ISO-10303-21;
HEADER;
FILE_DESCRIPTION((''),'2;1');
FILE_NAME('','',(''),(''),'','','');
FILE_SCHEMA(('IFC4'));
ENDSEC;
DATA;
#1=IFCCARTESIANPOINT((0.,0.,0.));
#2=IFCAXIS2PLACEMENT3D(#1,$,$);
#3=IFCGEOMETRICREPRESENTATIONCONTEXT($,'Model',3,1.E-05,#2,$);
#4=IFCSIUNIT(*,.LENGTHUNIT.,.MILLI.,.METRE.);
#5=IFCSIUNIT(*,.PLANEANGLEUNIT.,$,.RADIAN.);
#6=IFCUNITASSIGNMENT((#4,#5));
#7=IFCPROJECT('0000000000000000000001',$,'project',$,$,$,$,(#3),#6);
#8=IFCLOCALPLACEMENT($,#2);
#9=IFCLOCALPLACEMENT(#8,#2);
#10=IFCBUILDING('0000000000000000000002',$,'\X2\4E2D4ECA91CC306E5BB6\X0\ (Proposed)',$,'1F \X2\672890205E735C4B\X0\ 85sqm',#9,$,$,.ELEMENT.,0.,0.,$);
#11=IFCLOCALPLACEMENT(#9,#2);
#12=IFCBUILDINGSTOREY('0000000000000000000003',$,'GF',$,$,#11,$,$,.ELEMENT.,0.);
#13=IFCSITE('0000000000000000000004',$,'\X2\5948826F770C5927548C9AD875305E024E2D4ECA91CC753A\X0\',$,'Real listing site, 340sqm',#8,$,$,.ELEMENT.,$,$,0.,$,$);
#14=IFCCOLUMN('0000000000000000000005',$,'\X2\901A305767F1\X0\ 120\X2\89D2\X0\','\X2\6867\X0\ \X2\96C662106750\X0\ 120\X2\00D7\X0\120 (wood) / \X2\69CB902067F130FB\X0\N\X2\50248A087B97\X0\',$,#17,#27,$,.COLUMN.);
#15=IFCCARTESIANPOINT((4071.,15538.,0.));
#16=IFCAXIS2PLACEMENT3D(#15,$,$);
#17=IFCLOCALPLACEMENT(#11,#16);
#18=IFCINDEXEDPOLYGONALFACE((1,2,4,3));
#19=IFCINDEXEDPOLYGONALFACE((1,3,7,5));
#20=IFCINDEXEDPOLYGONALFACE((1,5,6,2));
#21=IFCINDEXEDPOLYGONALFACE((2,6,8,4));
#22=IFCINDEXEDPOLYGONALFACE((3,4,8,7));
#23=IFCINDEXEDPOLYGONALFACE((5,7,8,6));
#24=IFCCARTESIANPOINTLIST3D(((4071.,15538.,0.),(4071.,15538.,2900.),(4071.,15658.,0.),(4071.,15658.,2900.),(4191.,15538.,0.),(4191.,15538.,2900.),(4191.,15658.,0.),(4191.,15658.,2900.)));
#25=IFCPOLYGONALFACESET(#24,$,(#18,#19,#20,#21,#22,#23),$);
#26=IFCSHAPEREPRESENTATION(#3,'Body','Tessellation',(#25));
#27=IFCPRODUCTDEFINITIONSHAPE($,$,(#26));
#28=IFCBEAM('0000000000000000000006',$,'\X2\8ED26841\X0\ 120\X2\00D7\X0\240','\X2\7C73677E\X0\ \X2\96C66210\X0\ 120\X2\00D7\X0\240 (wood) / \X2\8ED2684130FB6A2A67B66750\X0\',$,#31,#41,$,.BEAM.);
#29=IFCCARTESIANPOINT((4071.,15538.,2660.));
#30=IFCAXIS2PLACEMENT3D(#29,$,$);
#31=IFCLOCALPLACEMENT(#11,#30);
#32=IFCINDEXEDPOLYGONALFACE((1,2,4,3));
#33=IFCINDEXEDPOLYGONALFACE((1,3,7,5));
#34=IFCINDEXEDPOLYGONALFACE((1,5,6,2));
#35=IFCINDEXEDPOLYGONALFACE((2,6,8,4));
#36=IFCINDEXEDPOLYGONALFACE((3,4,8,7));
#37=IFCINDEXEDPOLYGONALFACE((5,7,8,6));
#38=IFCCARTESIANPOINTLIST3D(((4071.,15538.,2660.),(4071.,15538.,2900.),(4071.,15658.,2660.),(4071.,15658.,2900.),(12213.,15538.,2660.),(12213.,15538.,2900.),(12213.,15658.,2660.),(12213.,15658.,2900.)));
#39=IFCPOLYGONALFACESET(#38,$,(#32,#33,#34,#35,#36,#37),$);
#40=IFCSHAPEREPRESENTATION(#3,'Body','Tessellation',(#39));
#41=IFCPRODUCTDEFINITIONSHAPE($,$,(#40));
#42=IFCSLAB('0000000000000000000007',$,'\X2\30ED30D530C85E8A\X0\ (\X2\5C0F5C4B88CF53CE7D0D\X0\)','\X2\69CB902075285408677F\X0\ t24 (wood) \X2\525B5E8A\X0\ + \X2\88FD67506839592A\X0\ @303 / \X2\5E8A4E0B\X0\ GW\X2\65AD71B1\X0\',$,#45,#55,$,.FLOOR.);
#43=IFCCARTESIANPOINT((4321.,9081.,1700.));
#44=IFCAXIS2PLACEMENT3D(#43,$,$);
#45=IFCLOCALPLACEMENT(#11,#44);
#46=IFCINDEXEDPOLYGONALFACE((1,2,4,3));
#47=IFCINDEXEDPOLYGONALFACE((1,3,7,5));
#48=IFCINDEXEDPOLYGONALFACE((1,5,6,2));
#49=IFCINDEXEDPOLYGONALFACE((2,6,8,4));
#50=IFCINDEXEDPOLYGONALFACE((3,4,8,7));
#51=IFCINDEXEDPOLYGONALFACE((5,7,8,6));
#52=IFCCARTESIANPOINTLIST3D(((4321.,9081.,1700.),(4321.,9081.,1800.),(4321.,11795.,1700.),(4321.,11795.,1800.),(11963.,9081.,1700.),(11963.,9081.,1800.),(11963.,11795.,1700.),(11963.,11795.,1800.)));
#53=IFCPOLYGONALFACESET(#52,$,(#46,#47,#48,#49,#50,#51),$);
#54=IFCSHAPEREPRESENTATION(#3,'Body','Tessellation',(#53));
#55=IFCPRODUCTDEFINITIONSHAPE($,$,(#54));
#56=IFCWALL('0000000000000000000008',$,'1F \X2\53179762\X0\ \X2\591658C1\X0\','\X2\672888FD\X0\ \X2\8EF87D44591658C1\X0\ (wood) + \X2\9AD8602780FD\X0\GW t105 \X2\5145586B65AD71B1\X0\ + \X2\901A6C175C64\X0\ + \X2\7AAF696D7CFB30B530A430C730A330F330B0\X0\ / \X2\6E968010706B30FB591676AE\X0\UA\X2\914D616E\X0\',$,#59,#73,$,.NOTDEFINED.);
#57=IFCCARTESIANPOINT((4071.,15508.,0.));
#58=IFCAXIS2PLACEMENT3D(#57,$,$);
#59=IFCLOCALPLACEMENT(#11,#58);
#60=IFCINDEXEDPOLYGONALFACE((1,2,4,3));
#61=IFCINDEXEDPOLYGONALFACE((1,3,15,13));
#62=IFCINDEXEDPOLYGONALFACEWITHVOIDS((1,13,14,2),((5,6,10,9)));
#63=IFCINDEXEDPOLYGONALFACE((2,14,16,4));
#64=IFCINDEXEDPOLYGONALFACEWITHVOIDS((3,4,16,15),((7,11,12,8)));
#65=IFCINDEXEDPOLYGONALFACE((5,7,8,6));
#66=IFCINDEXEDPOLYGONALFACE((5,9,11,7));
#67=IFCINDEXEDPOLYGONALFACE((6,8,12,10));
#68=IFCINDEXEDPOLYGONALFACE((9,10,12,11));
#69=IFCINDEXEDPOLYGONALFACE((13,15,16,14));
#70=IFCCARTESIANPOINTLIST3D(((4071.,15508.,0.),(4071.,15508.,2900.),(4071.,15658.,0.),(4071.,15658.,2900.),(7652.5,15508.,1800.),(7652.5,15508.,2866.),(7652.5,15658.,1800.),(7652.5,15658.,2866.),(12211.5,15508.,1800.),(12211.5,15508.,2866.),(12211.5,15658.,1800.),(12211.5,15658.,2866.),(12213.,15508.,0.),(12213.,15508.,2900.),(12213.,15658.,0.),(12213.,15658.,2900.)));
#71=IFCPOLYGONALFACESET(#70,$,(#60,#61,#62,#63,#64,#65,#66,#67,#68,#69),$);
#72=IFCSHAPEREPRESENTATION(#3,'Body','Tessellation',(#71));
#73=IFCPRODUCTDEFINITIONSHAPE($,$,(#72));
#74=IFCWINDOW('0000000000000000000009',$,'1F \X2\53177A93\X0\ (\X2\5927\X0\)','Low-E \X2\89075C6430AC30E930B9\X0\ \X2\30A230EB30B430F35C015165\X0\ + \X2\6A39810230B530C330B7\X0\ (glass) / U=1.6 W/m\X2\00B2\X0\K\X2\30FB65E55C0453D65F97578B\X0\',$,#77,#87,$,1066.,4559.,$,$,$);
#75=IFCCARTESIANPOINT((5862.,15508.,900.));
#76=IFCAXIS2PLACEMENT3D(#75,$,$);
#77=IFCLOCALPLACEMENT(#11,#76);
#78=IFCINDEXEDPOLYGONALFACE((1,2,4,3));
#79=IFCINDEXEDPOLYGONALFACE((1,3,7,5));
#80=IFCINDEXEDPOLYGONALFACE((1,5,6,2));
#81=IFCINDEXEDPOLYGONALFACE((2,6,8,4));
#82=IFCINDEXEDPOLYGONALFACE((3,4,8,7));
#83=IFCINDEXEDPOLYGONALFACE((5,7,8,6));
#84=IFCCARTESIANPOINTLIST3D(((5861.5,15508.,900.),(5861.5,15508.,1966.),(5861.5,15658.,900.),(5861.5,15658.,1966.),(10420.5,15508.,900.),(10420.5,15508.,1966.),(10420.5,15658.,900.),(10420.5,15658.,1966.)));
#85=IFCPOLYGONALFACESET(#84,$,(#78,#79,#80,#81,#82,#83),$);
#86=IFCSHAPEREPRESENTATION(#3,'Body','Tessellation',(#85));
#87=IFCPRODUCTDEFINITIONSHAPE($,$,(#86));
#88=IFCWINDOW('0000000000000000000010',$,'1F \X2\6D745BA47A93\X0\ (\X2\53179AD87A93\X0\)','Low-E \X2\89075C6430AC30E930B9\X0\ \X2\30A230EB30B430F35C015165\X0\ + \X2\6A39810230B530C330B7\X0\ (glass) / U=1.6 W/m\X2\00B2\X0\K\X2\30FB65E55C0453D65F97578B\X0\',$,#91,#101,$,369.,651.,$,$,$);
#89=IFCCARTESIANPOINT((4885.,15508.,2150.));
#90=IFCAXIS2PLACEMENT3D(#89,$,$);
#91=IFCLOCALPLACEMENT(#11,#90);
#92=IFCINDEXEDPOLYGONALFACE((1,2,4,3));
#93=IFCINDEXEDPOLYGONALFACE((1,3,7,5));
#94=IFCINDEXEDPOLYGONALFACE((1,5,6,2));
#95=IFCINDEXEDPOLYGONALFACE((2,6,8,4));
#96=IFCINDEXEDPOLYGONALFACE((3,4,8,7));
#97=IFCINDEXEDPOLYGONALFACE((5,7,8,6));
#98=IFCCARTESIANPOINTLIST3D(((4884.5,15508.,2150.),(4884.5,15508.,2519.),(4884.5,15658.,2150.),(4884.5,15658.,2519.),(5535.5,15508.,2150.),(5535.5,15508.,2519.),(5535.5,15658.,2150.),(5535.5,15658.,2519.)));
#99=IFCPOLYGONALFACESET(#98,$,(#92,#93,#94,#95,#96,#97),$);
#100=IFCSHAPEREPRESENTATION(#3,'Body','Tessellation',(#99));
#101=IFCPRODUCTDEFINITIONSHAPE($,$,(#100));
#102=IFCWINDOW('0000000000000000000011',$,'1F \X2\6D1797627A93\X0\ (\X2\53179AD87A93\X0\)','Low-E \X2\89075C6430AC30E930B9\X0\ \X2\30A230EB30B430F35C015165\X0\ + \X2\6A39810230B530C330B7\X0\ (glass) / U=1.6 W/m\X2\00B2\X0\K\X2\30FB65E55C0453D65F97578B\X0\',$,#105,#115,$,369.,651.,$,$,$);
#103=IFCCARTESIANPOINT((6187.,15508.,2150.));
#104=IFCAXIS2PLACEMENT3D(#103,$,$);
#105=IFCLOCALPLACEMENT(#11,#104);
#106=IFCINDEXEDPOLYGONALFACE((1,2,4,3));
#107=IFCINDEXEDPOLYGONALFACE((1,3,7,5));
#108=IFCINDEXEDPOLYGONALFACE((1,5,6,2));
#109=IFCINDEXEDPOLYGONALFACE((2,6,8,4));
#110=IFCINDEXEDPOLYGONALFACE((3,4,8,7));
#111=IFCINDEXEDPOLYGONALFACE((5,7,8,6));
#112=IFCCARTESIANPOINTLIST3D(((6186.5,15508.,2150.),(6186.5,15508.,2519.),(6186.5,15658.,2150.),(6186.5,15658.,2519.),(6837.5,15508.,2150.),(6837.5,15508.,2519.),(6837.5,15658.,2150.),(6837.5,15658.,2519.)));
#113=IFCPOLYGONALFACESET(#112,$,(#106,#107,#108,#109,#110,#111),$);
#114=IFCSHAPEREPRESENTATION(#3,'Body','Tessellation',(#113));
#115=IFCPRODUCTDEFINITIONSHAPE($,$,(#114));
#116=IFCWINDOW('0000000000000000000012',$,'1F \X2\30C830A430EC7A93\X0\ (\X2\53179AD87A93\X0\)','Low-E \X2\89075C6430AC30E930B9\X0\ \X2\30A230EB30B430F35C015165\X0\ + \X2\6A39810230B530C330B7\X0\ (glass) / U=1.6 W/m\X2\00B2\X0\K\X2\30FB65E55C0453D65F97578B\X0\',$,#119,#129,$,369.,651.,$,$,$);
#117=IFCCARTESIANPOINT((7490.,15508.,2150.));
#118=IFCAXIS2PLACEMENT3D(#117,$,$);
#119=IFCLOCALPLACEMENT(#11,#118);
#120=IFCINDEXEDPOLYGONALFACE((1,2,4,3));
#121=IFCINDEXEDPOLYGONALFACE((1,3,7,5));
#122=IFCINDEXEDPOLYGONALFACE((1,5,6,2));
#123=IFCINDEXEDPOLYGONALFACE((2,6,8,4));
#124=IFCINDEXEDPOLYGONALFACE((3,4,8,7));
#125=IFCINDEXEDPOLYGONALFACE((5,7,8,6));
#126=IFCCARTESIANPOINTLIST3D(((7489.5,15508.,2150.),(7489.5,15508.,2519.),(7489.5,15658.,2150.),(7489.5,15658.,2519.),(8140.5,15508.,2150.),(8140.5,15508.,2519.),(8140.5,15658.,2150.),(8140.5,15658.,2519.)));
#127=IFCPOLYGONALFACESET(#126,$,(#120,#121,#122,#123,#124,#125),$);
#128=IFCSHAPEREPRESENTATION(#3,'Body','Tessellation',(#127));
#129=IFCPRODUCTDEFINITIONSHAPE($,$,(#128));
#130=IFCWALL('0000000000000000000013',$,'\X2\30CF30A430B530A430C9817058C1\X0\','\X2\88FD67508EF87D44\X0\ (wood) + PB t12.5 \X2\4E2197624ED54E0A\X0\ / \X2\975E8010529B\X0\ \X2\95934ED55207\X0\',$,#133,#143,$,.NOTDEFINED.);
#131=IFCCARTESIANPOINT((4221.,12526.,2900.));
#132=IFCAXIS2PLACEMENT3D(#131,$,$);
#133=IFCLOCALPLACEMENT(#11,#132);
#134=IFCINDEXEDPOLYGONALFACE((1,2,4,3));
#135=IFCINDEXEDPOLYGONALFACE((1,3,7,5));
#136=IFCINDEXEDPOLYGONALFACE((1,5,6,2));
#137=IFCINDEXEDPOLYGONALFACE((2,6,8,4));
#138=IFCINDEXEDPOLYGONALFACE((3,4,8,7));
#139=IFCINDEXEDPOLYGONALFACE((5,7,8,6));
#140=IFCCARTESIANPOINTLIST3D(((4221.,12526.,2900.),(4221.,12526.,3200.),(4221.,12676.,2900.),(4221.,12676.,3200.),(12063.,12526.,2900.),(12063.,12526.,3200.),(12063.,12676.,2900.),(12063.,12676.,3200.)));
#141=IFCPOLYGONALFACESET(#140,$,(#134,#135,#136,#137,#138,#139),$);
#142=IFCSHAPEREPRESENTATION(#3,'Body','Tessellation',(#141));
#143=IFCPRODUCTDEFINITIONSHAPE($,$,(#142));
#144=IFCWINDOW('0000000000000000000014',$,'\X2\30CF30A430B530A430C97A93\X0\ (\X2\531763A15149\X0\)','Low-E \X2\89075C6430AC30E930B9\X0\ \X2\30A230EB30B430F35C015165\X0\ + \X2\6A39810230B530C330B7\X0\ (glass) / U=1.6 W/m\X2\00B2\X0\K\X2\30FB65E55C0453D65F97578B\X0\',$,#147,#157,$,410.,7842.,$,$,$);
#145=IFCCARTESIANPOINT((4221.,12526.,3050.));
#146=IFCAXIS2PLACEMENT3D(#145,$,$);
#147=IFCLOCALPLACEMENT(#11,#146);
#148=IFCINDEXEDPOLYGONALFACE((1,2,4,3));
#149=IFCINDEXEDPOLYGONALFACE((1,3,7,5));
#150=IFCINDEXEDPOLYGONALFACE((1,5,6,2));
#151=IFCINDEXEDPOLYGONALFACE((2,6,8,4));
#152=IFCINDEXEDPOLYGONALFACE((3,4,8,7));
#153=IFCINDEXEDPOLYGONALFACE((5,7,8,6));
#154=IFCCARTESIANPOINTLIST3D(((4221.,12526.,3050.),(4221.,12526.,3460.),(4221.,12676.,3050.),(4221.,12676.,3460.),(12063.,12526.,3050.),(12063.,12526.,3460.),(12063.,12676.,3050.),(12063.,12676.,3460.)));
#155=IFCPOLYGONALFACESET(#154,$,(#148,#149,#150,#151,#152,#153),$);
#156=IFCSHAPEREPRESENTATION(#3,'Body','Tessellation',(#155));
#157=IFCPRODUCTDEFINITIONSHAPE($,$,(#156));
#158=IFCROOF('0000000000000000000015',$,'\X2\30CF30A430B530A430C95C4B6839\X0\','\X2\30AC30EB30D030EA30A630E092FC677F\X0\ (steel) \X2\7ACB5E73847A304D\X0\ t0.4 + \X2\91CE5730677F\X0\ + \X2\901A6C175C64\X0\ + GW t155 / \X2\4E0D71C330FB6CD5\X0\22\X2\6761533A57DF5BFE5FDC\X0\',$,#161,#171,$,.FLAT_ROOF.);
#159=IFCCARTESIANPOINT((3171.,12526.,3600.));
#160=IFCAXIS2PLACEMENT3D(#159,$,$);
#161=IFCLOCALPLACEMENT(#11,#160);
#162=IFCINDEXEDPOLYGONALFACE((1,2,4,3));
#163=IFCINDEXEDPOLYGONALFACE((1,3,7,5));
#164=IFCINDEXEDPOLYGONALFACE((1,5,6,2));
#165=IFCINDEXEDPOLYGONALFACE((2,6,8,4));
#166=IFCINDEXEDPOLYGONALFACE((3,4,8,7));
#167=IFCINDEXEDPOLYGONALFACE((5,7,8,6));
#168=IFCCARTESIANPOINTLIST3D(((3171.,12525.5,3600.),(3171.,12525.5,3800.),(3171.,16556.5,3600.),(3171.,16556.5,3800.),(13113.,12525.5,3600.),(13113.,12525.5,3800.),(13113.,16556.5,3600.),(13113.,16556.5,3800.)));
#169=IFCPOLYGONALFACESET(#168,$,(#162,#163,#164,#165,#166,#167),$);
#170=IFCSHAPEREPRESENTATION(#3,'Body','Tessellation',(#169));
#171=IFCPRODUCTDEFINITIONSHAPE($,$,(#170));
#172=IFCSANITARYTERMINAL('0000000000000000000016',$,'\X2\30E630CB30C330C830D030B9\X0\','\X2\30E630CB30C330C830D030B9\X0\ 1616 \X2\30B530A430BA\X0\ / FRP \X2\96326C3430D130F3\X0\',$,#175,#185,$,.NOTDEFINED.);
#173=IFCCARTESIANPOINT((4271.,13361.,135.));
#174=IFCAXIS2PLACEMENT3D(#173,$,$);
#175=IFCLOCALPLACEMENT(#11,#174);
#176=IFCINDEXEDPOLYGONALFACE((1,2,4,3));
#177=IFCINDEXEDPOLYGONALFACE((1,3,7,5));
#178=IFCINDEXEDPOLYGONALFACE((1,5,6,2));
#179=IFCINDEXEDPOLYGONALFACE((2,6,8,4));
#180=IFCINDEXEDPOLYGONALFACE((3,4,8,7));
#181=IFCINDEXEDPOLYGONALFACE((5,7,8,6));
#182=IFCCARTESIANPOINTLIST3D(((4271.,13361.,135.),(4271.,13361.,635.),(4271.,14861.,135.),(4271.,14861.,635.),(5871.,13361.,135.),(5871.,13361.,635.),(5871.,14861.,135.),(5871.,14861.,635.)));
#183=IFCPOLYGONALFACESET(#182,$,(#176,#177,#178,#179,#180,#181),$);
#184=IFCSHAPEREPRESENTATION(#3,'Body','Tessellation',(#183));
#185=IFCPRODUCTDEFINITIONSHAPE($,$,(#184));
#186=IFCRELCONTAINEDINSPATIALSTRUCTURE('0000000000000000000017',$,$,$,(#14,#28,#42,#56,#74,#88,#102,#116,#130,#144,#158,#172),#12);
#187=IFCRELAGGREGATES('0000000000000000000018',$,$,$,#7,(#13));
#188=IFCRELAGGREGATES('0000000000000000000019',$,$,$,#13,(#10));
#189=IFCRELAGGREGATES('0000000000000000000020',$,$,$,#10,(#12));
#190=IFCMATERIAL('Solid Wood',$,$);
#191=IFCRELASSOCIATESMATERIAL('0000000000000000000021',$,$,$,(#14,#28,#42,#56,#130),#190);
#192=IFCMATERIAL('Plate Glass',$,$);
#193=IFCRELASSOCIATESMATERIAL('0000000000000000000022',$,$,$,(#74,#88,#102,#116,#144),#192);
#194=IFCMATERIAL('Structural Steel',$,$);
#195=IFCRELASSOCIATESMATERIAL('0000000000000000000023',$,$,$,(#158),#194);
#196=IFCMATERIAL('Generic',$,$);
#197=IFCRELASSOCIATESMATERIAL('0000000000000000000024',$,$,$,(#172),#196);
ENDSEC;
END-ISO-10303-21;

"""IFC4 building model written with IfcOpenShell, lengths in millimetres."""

from ifc_helpers import new_model, si_unit, frame, frame_2d, origin, place, context, project, spatial, rectangle, extrude, material, element, fill, save


model = new_model("IFC4")

# Units and contexts
model_context = context("Model", 3, precision=1e-05, world=origin())
ifc_project = project(units=[si_unit("LENGTHUNIT", "METRE", prefix="MILLI"), si_unit("PLANEANGLEUNIT", "RADIAN")], contexts=[model_context])

# Site, building, storey
site_placement = place(None, origin())
site = spatial("IfcSite", under=ifc_project, at=site_placement, Name="奈良県大和高田市中今里町", ObjectType="Real listing site, 340sqm", CompositionType="ELEMENT", RefElevation=0.0)
building_placement = place(site_placement, origin())
building = spatial("IfcBuilding", under=site, at=building_placement, Name="中今里の家 (Proposed)", ObjectType="1F 木造平屋 85sqm", CompositionType="ELEMENT", ElevationOfRefHeight=0.0, ElevationOfTerrain=0.0)
storey_placement = place(building_placement, origin())
storey = spatial("IfcBuildingStorey", under=building, at=storey_placement, Name="GF", CompositionType="ELEMENT", Elevation=0.0)

# Column
ifc_material_1 = material(Name="Solid Wood")
column_1_placement = place(storey_placement, frame((4071.0, 15538.0, 0.0)))
element("IfcColumn", 1, at=column_1_placement, inside=storey, material=ifc_material_1, Name="通し柱 120角", Description="桧 集成材 120×120 (wood) / 構造柱・N値計算", PredefinedType="COLUMN", context=model_context, shape_type="SweptSolid", body=[
    extrude(rectangle(XDim=120.0, YDim=120.0, at=frame_2d((60.0, 60.0))), frame((4071.0, 15538.0, 0.0)), (0.0, 0.0, 1.0), 2900.0),
])

# Beam
beam_1_placement = place(storey_placement, frame((4071.0, 15538.0, 2660.0)))
element("IfcBeam", 2, at=beam_1_placement, inside=storey, material=ifc_material_1, Name="軒桁 120×240", Description="米松 集成 120×240 (wood) / 軒桁・横架材", PredefinedType="BEAM", context=model_context, shape_type="SweptSolid", body=[
    extrude(rectangle(XDim=8142.0, YDim=120.0, at=frame_2d((4071.0, 60.0))), frame((4071.0, 15538.0, 2660.0)), (0.0, 0.0, 1.0), 240.0),
])

# Slab
slab_placement = place(storey_placement, frame((4321.0, 9081.0, 1700.0)))
element("IfcSlab", 3, at=slab_placement, inside=storey, material=ifc_material_1, Name="ロフト床 (小屋裏収納)", Description="構造用合板 t24 (wood) 剛床 + 製材根太 @303 / 床下 GW断熱", PredefinedType="FLOOR", context=model_context, shape_type="SweptSolid", body=[
    extrude(rectangle(XDim=7642.0, YDim=2714.0, at=frame_2d((3821.0, 1357.0))), frame((4321.0, 9081.0, 1700.0)), (0.0, 0.0, 1.0), 100.0),
])

# Wall, openings, windows
wall_1_placement = place(storey_placement, frame((4071.0, 15508.0, 0.0)))
wall_1 = element("IfcWall", 4, at=wall_1_placement, inside=storey, material=ifc_material_1, Name="1F 北面 外壁", Description="木製 軸組外壁 (wood) + 高性能GW t105 充填断熱 + 通気層 + 窯業系サイディング / 準耐火・外皮UA配慮", PredefinedType="NOTDEFINED", context=model_context, shape_type="SweptSolid", body=[
    extrude(rectangle(XDim=8142.0, YDim=150.0, at=frame_2d((4071.0, 75.0))), frame((4071.0, 15508.0, 0.0)), (0.0, 0.0, 1.0), 2900.0),
])
opening_1_placement = place(storey_placement, frame((5862.0, 15508.0, 900.0)))
opening_1 = element("IfcOpeningElement", 5, at=opening_1_placement, cuts=wall_1, PredefinedType="NOTDEFINED", context=model_context, shape_type="SweptSolid", body=[
    extrude(rectangle(XDim=4559.0, YDim=150.0, at=frame_2d((2279.0, 75.0))), frame((5862.0, 15508.0, 900.0)), (0.0, 0.0, 1.0), 1066.0),
])
opening_2_placement = place(storey_placement, frame((4885.0, 15508.0, 2150.0)))
opening_2 = element("IfcOpeningElement", 6, at=opening_2_placement, cuts=wall_1, PredefinedType="NOTDEFINED", context=model_context, shape_type="SweptSolid", body=[
    extrude(rectangle(XDim=651.0, YDim=150.0, at=frame_2d((325.0, 75.0))), frame((4885.0, 15508.0, 2150.0)), (0.0, 0.0, 1.0), 369.0),
])
opening_3_placement = place(storey_placement, frame((6187.0, 15508.0, 2150.0)))
opening_3 = element("IfcOpeningElement", 7, at=opening_3_placement, cuts=wall_1, PredefinedType="NOTDEFINED", context=model_context, shape_type="SweptSolid", body=[
    extrude(rectangle(XDim=651.0, YDim=150.0, at=frame_2d((325.0, 75.0))), frame((6187.0, 15508.0, 2150.0)), (0.0, 0.0, 1.0), 369.0),
])
opening_4_placement = place(storey_placement, frame((7490.0, 15508.0, 2150.0)))
opening_4 = element("IfcOpeningElement", 8, at=opening_4_placement, cuts=wall_1, PredefinedType="NOTDEFINED", context=model_context, shape_type="SweptSolid", body=[
    extrude(rectangle(XDim=651.0, YDim=150.0, at=frame_2d((325.0, 75.0))), frame((7490.0, 15508.0, 2150.0)), (0.0, 0.0, 1.0), 369.0),
])
ifc_material_2 = material(Name="Plate Glass")
window_1_placement = place(storey_placement, frame((5862.0, 15508.0, 900.0)))
window_1 = element("IfcWindow", 9, at=window_1_placement, inside=storey, material=ifc_material_2, Name="1F 北窓 (大)", Description="Low-E 複層ガラス アルゴン封入 + 樹脂サッシ (glass) / U=1.6 W/m²K・日射取得型", OverallHeight=1066.0, OverallWidth=4559.0, context=model_context, shape_type="SweptSolid", body=[
    extrude(rectangle(XDim=4559.0, YDim=150.0, at=frame_2d((2279.0, 75.0))), frame((5862.0, 15508.0, 900.0)), (0.0, 0.0, 1.0), 1066.0),
])
fill(opening_1, window_1)
window_2_placement = place(storey_placement, frame((4885.0, 15508.0, 2150.0)))
window_2 = element("IfcWindow", 10, at=window_2_placement, inside=storey, material=ifc_material_2, Name="1F 浴室窓 (北高窓)", Description="Low-E 複層ガラス アルゴン封入 + 樹脂サッシ (glass) / U=1.6 W/m²K・日射取得型", OverallHeight=369.0, OverallWidth=651.0, context=model_context, shape_type="SweptSolid", body=[
    extrude(rectangle(XDim=651.0, YDim=150.0, at=frame_2d((325.0, 75.0))), frame((4885.0, 15508.0, 2150.0)), (0.0, 0.0, 1.0), 369.0),
])
fill(opening_2, window_2)
window_3_placement = place(storey_placement, frame((6187.0, 15508.0, 2150.0)))
window_3 = element("IfcWindow", 11, at=window_3_placement, inside=storey, material=ifc_material_2, Name="1F 洗面窓 (北高窓)", Description="Low-E 複層ガラス アルゴン封入 + 樹脂サッシ (glass) / U=1.6 W/m²K・日射取得型", OverallHeight=369.0, OverallWidth=651.0, context=model_context, shape_type="SweptSolid", body=[
    extrude(rectangle(XDim=651.0, YDim=150.0, at=frame_2d((325.0, 75.0))), frame((6187.0, 15508.0, 2150.0)), (0.0, 0.0, 1.0), 369.0),
])
fill(opening_3, window_3)
window_4_placement = place(storey_placement, frame((7490.0, 15508.0, 2150.0)))
window_4 = element("IfcWindow", 12, at=window_4_placement, inside=storey, material=ifc_material_2, Name="1F トイレ窓 (北高窓)", Description="Low-E 複層ガラス アルゴン封入 + 樹脂サッシ (glass) / U=1.6 W/m²K・日射取得型", OverallHeight=369.0, OverallWidth=651.0, context=model_context, shape_type="SweptSolid", body=[
    extrude(rectangle(XDim=651.0, YDim=150.0, at=frame_2d((325.0, 75.0))), frame((7490.0, 15508.0, 2150.0)), (0.0, 0.0, 1.0), 369.0),
])
fill(opening_4, window_4)

# Wall, opening, window
wall_2_placement = place(storey_placement, frame((4221.0, 12526.0, 2900.0)))
wall_2 = element("IfcWall", 13, at=wall_2_placement, inside=storey, material=ifc_material_1, Name="ハイサイド腰壁", Description="製材軸組 (wood) + PB t12.5 両面仕上 / 非耐力 間仕切", PredefinedType="NOTDEFINED", context=model_context, shape_type="SweptSolid", body=[
    extrude(rectangle(XDim=7842.0, YDim=150.0, at=frame_2d((3921.0, 75.0))), frame((4221.0, 12526.0, 2900.0)), (0.0, 0.0, 1.0), 700.0),
])
opening_5_placement = place(storey_placement, frame((4221.0, 12526.0, 3050.0)))
opening_5 = element("IfcOpeningElement", 14, at=opening_5_placement, cuts=wall_2, PredefinedType="NOTDEFINED", context=model_context, shape_type="SweptSolid", body=[
    extrude(rectangle(XDim=7842.0, YDim=150.0, at=frame_2d((3921.0, 75.0))), frame((4221.0, 12526.0, 3050.0)), (0.0, 0.0, 1.0), 410.0),
])
window_5_placement = place(storey_placement, frame((4221.0, 12526.0, 3050.0)))
window_5 = element("IfcWindow", 15, at=window_5_placement, inside=storey, material=ifc_material_2, Name="ハイサイド窓 (北採光)", Description="Low-E 複層ガラス アルゴン封入 + 樹脂サッシ (glass) / U=1.6 W/m²K・日射取得型", OverallHeight=410.0, OverallWidth=7842.0, context=model_context, shape_type="SweptSolid", body=[
    extrude(rectangle(XDim=7842.0, YDim=150.0, at=frame_2d((3921.0, 75.0))), frame((4221.0, 12526.0, 3050.0)), (0.0, 0.0, 1.0), 410.0),
])
fill(opening_5, window_5)

# Roof
ifc_material_3 = material(Name="Structural Steel")
roof_placement = place(storey_placement, frame((3171.0, 12526.0, 3600.0)))
element("IfcRoof", 16, at=roof_placement, inside=storey, material=ifc_material_3, Name="ハイサイド屋根", Description="ガルバリウム鋼板 (steel) 立平葺き t0.4 + 野地板 + 通気層 + GW t155 / 不燃・法22条区域対応", PredefinedType="FLAT_ROOF", context=model_context, shape_type="SweptSolid", body=[
    extrude(rectangle(XDim=9942.0, YDim=4031.0, at=frame_2d((4971.0, 2015.0))), frame((3171.0, 12526.0, 3600.0)), (0.0, 0.0, 1.0), 200.0),
])

# Sanitary terminal
ifc_material_4 = material(Name="Generic")
sanitary_terminal_placement = place(storey_placement, frame((4271.0, 13361.0, 135.0)))
element("IfcSanitaryTerminal", 17, at=sanitary_terminal_placement, inside=storey, material=ifc_material_4, Name="ユニットバス", Description="ユニットバス 1616 サイズ / FRP 防水パン", PredefinedType="NOTDEFINED", context=model_context, shape_type="SweptSolid", body=[
    extrude(rectangle(XDim=1600.0, YDim=1500.0, at=frame_2d((800.0, 750.0))), frame((4271.0, 13361.0, 135.0)), (0.0, 0.0, 1.0), 500.0),
])

save(model, "model.ifc")
